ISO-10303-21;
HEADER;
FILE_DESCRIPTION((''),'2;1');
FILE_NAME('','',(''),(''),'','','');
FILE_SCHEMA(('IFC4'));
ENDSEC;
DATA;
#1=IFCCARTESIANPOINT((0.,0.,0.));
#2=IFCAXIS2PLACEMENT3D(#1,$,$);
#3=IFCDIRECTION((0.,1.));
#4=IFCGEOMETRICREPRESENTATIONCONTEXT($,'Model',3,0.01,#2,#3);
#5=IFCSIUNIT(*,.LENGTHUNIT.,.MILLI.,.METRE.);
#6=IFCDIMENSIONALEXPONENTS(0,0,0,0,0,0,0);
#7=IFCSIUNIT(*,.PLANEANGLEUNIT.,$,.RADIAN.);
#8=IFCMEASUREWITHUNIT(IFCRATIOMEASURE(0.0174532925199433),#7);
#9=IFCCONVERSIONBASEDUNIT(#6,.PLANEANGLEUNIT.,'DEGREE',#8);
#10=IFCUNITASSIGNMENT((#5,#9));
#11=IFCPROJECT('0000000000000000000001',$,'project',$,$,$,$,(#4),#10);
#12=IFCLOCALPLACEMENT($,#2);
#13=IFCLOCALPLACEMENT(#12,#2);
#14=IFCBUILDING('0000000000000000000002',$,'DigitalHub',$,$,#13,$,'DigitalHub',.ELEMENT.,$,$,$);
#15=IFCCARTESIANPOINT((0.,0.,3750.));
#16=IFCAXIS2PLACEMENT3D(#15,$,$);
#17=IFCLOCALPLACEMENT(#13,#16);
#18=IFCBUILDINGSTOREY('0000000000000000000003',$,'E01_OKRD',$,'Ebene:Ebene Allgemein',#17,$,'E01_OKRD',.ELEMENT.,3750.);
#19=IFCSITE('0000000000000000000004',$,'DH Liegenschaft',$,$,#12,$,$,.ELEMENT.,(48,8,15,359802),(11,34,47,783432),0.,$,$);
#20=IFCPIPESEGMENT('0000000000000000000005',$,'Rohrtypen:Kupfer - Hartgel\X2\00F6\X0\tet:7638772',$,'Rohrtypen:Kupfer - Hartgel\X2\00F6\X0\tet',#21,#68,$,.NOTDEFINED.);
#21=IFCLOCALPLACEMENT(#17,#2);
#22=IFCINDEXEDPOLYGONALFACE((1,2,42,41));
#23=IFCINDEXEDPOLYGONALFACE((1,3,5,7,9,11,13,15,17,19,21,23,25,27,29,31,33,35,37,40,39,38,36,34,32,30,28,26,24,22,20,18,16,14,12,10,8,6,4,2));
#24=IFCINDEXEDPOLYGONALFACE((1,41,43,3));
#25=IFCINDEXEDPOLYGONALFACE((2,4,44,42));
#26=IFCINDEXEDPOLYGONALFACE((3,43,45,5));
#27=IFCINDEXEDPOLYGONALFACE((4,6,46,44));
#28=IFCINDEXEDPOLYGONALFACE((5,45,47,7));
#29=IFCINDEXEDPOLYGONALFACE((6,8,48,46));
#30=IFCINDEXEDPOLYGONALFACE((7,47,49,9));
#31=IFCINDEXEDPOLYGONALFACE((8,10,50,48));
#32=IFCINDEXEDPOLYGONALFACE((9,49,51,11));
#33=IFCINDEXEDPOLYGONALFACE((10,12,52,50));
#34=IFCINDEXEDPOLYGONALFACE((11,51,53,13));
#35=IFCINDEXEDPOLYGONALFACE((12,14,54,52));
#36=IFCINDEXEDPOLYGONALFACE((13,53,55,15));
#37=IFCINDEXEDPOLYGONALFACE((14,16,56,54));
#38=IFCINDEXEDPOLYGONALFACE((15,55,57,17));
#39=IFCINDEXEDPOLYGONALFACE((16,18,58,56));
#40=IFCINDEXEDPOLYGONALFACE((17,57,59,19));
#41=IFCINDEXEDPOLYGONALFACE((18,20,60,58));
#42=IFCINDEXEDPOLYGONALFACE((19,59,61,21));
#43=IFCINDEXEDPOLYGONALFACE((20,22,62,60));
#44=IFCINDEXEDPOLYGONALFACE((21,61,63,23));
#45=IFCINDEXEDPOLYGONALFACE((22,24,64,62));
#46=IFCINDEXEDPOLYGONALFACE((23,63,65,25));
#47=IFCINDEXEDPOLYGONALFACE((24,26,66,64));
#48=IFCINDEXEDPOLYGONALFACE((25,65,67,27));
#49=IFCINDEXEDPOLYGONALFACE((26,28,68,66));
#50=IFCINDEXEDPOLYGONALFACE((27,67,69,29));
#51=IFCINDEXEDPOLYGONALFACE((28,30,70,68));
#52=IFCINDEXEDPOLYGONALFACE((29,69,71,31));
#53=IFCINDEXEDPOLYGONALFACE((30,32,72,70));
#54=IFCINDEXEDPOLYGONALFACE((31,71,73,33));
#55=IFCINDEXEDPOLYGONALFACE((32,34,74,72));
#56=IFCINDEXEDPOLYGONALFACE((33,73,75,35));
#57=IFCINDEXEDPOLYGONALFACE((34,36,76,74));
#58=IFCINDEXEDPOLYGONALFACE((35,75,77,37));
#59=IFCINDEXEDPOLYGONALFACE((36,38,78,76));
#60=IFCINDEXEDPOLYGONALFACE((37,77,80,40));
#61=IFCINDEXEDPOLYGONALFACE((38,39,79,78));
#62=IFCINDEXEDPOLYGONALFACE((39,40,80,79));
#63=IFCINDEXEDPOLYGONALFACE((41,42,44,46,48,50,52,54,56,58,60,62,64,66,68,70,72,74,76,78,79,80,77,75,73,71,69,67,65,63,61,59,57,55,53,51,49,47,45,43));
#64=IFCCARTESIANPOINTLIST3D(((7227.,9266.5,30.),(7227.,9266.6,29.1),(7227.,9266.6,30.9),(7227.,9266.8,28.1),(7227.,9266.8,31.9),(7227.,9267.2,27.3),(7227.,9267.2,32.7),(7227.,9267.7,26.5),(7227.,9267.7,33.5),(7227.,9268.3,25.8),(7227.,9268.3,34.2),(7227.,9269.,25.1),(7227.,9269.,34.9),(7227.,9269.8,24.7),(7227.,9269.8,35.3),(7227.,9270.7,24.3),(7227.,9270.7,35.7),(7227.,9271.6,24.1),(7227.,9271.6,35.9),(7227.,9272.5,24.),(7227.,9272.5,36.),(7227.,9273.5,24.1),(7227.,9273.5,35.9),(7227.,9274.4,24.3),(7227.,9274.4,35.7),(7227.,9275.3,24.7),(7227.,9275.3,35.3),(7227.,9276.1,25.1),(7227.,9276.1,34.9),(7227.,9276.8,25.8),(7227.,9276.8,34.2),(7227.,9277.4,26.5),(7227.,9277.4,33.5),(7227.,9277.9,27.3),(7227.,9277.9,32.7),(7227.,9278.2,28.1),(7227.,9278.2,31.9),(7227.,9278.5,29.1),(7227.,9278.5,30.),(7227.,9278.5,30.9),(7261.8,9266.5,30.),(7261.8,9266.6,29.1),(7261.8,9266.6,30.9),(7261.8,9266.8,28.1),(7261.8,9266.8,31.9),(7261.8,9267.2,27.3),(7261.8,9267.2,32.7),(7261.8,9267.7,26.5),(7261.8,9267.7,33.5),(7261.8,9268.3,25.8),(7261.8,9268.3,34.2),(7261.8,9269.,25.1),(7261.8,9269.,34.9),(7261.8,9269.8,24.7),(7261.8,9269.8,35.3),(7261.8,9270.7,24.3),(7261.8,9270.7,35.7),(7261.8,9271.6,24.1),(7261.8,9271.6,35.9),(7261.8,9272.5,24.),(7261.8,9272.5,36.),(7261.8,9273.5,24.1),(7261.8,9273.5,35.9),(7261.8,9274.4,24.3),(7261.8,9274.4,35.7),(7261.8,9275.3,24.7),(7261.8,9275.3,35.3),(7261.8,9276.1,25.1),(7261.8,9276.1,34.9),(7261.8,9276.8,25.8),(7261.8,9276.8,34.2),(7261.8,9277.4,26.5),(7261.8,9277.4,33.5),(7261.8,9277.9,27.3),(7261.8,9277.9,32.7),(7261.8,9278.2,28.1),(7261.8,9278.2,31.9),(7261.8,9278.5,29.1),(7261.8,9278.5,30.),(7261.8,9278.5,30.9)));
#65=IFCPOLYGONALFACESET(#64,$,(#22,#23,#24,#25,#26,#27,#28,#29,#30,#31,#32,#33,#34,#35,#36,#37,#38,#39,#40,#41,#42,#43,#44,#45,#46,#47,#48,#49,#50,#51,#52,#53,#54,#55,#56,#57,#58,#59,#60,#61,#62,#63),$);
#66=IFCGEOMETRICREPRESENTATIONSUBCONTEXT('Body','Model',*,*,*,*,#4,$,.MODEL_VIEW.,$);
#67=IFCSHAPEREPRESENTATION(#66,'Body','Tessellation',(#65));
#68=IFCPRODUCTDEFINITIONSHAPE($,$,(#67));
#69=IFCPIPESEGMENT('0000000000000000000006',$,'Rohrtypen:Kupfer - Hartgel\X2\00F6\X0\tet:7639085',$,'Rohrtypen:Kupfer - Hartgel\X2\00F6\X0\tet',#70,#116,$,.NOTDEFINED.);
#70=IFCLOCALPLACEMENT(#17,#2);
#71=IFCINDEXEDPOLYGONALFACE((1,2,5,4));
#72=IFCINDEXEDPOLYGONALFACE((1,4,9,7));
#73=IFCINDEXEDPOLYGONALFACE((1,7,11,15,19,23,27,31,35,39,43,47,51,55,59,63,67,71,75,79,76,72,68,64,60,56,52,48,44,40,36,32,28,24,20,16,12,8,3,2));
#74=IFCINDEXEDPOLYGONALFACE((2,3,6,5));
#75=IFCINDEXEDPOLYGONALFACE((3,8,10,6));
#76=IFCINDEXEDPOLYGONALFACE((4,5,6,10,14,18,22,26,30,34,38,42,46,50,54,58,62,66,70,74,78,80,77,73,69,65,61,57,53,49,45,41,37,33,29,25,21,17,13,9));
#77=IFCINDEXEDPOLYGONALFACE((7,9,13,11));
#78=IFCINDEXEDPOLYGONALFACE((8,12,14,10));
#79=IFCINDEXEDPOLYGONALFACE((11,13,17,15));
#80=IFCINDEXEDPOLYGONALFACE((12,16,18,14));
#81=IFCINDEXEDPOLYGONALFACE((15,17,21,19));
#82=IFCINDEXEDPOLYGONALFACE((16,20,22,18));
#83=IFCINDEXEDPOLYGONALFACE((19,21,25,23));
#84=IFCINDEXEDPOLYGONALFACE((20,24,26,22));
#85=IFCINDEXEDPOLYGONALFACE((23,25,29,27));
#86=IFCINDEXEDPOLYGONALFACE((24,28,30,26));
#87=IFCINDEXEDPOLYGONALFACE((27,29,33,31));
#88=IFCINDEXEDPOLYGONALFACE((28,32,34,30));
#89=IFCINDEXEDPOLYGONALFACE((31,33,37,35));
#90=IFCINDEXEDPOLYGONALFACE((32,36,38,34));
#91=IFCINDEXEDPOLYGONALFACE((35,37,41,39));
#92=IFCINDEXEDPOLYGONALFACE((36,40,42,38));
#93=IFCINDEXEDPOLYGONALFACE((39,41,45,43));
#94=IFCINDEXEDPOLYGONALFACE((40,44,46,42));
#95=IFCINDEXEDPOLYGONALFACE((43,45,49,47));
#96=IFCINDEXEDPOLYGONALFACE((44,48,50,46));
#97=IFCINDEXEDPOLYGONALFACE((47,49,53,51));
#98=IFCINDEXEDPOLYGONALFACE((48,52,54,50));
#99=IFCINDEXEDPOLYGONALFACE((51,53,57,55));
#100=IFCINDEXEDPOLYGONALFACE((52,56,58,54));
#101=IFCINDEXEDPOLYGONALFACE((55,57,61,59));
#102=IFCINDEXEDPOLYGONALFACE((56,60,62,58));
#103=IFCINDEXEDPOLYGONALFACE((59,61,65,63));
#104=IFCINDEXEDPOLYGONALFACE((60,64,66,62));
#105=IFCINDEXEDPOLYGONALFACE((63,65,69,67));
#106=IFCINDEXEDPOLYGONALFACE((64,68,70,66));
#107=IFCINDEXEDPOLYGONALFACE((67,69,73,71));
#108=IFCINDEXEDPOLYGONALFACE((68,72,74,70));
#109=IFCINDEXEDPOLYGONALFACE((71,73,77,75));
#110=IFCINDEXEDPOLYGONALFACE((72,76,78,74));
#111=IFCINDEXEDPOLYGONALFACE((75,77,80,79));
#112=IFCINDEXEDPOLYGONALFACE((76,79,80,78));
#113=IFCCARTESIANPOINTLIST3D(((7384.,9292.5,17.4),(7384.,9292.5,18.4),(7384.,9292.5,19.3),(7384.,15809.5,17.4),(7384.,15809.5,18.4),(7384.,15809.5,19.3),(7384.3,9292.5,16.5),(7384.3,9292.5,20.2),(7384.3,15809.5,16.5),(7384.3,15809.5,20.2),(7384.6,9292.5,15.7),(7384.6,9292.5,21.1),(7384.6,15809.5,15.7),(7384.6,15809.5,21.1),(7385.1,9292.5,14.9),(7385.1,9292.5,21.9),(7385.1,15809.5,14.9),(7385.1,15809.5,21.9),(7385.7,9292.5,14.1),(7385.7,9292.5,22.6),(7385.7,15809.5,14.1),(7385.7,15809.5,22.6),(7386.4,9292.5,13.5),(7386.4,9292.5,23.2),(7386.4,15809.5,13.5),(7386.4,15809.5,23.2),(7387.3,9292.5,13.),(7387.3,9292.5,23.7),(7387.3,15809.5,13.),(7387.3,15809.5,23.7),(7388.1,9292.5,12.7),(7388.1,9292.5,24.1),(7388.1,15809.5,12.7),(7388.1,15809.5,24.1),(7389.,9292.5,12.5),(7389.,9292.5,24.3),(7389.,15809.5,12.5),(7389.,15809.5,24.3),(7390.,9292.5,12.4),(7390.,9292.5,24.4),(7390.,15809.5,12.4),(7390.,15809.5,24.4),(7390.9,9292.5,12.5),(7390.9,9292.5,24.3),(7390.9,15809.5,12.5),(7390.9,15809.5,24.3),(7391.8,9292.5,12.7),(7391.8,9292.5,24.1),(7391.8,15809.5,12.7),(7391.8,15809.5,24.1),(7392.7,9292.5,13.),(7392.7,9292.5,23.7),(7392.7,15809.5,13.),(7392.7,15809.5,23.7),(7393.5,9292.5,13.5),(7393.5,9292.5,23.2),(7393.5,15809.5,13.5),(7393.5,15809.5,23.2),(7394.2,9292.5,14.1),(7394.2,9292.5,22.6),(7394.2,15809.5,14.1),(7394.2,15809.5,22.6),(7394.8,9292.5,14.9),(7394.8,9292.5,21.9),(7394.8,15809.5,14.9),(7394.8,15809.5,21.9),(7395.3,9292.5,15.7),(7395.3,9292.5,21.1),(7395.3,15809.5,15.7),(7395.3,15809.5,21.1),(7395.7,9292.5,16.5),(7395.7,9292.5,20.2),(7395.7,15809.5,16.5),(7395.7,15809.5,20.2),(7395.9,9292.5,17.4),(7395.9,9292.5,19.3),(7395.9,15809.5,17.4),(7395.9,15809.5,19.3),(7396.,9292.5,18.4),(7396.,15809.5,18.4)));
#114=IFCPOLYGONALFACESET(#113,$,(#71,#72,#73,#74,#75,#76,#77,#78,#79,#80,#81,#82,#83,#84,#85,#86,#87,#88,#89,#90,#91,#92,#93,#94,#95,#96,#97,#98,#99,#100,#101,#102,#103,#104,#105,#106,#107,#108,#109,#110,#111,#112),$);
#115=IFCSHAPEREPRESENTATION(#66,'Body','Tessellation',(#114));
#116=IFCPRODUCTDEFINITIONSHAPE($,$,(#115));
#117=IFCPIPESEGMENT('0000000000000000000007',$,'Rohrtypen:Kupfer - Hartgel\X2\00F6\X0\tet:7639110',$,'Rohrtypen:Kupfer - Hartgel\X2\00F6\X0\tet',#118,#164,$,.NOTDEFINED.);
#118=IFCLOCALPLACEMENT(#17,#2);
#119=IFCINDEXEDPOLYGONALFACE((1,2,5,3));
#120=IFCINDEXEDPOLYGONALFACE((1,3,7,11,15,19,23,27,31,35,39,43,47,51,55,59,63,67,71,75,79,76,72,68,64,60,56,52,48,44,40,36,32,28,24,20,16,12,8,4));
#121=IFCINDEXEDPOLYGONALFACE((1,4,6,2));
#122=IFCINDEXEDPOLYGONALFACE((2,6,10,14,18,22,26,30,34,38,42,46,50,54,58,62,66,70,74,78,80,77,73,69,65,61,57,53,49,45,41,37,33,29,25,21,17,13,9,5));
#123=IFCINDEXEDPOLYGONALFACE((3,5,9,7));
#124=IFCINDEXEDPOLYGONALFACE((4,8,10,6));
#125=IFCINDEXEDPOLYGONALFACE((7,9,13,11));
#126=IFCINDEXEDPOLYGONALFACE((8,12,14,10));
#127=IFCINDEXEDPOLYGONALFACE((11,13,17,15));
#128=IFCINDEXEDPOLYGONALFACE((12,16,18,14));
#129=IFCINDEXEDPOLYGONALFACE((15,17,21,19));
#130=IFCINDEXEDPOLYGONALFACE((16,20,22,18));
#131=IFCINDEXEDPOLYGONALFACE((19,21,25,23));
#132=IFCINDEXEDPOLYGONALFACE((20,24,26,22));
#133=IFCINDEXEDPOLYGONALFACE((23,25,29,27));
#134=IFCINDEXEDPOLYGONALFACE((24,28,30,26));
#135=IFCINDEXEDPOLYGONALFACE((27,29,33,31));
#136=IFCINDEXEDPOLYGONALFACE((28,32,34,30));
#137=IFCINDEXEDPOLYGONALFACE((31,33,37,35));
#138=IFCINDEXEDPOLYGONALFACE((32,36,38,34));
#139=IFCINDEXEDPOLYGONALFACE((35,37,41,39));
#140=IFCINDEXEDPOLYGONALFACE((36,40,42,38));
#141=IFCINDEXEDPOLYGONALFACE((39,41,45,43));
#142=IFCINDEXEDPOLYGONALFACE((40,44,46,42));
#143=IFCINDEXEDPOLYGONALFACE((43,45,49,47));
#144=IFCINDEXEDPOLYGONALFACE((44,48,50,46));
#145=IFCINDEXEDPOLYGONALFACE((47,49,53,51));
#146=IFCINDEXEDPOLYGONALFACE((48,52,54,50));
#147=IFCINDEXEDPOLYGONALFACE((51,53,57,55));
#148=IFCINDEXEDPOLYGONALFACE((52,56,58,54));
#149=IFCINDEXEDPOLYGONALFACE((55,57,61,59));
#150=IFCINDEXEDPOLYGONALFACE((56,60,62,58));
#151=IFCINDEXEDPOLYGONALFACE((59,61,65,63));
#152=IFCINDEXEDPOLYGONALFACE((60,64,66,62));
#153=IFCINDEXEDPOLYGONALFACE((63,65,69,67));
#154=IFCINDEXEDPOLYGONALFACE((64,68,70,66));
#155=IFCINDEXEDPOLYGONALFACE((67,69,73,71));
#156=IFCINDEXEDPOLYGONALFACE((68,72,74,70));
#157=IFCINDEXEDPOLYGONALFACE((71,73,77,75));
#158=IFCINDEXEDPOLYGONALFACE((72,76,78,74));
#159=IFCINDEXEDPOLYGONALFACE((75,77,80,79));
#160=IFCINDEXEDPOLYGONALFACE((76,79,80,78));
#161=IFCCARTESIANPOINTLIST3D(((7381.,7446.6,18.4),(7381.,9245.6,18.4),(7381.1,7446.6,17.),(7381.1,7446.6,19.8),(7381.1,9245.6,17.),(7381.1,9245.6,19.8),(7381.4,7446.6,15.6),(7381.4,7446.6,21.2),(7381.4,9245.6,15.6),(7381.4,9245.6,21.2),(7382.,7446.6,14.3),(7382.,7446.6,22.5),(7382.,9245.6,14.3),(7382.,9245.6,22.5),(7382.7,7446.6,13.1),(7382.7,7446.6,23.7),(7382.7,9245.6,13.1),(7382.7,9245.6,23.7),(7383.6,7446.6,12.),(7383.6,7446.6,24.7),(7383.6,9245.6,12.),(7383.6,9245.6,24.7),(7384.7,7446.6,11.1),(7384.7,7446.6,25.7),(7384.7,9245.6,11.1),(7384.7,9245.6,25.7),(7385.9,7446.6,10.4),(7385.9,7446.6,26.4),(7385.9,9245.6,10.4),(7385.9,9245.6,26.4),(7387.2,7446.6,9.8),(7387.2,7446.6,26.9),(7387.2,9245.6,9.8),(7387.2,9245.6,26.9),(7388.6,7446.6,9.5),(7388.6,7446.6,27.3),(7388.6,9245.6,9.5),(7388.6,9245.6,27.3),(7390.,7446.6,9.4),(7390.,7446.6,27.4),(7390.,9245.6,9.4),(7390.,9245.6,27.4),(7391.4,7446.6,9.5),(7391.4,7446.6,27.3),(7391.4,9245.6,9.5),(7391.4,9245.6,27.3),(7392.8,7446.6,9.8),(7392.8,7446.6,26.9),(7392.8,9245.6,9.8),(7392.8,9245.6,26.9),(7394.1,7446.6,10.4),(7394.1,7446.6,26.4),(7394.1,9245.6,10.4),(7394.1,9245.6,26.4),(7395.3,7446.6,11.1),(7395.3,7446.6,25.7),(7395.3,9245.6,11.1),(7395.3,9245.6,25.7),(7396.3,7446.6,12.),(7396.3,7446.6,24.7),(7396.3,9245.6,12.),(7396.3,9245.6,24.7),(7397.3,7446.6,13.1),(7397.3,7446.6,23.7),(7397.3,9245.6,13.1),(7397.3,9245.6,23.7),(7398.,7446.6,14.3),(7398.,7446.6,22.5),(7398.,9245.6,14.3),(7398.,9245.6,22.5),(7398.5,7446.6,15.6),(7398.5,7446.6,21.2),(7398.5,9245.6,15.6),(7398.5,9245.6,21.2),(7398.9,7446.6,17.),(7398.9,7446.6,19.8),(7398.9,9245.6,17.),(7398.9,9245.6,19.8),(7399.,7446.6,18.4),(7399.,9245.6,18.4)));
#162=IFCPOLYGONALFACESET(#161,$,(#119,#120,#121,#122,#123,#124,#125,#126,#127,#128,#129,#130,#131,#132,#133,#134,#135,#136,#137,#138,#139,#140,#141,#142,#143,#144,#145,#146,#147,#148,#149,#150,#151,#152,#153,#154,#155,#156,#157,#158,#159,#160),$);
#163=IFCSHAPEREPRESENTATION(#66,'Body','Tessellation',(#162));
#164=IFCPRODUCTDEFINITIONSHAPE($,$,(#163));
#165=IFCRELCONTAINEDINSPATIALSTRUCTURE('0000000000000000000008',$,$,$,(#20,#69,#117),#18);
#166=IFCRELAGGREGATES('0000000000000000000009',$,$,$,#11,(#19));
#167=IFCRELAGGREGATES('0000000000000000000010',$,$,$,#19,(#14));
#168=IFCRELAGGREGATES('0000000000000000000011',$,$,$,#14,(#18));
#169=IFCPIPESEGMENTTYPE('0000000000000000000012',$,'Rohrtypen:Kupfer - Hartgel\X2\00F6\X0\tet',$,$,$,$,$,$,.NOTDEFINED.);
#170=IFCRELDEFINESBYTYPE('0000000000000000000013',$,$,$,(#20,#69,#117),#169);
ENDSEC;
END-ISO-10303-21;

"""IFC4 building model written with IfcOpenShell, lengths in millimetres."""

from ifc_helpers import new_model, entity, si_unit, converted_unit, direction, frame, origin, place, context, subcontext, project, spatial, indexed_curve, outline, extrude, type_object, element, save


model = new_model("IFC4")

# Units and contexts
model_context = context("Model", 3, precision=0.01, world=origin(), true_north=direction((0.0, 1.0)))
body_context = subcontext(model_context, "Body", "Model", "MODEL_VIEW")
ifc_project = project(units=[si_unit("LENGTHUNIT", "METRE", prefix="MILLI"), converted_unit("PLANEANGLEUNIT", "DEGREE", entity("IfcRatioMeasure", 0.0174532925199433), si_unit("PLANEANGLEUNIT", "RADIAN"), dimensions=[0, 0, 0, 0, 0, 0, 0])], contexts=[model_context])

# Site, building, storey
site_placement = place(None, origin())
site = spatial("IfcSite", under=ifc_project, at=site_placement, Name="DH Liegenschaft", CompositionType="ELEMENT", RefLatitude=(48, 8, 15, 359802), RefLongitude=(11, 34, 47, 783432), RefElevation=0.0)
building_placement = place(site_placement, origin())
building = spatial("IfcBuilding", under=site, at=building_placement, Name="DigitalHub", LongName="DigitalHub", CompositionType="ELEMENT")
storey_placement = place(building_placement, frame((0.0, 0.0, 3750.0)))
storey = spatial("IfcBuildingStorey", under=building, at=storey_placement, Name="E01_OKRD", ObjectType="Ebene:Ebene Allgemein", LongName="E01_OKRD", CompositionType="ELEMENT", Elevation=3750.0)

# Pipe segments
pipe_segment_type = type_object("IfcPipeSegmentType", Name="Rohrtypen:Kupfer - Hartgelötet", PredefinedType="NOTDEFINED")
pipe_segment_1_placement = place(storey_placement, frame((7227.0, 9264.9, 22.4)))
element("IfcPipeSegment", 1, at=pipe_segment_1_placement, inside=storey, type_object=pipe_segment_type, Name="Rohrtypen:Kupfer - Hartgelötet:7638772", ObjectType="Rohrtypen:Kupfer - Hartgelötet", PredefinedType="NOTDEFINED", context=body_context, shape_type="SweptSolid", body=[
    extrude(outline(indexed_curve([(6.0, 0.0), (5.9, 0.9), (5.7, 1.9), (5.3, 2.7), (4.9, 3.5), (4.2, 4.2), (3.5, 4.9), (2.7, 5.3), (1.9, 5.7), (0.9, 5.9), (0.0, 6.0), (-0.9, 5.9), (-1.9, 5.7), (-2.7, 5.3), (-3.5, 4.9), (-4.2, 4.2), (-4.9, 3.5), (-5.3, 2.7), (-5.7, 1.9), (-5.9, 0.9), (-6.0, 0.0), (-5.9, -0.9), (-5.7, -1.9), (-5.3, -2.7), (-4.9, -3.5), (-4.2, -4.2), (-3.5, -4.9), (-2.7, -5.3), (-1.9, -5.7), (-0.9, -5.9), (0.0, -6.0), (0.9, -5.9), (1.9, -5.7), (2.7, -5.3), (3.5, -4.9), (4.2, -4.2), (4.9, -3.5), (5.3, -2.7), (5.7, -1.9), (5.9, -0.9), (6.0, 0.0)], self_intersect=False)), frame((0.0, 7.6, 7.6), z_axis=(1.0, 0.0, 0.0), x_axis=(0.0, 1.0, 0.0)), (0.0, 0.0, 1.0), 34.9),
])
pipe_segment_2_placement = place(storey_placement, frame((7382.4, 9292.5, 10.8)))
element("IfcPipeSegment", 2, at=pipe_segment_2_placement, inside=storey, type_object=pipe_segment_type, Name="Rohrtypen:Kupfer - Hartgelötet:7639085", ObjectType="Rohrtypen:Kupfer - Hartgelötet", PredefinedType="NOTDEFINED", context=body_context, shape_type="SweptSolid", body=[
    extrude(outline(indexed_curve([(6.0, 0.0), (5.9, 0.9), (5.7, 1.9), (5.3, 2.7), (4.9, 3.5), (4.2, 4.2), (3.5, 4.9), (2.7, 5.3), (1.9, 5.7), (0.9, 5.9), (0.0, 6.0), (-0.9, 5.9), (-1.9, 5.7), (-2.7, 5.3), (-3.5, 4.9), (-4.2, 4.2), (-4.9, 3.5), (-5.3, 2.7), (-5.7, 1.9), (-5.9, 0.9), (-6.0, 0.0), (-5.9, -0.9), (-5.7, -1.9), (-5.3, -2.7), (-4.9, -3.5), (-4.2, -4.2), (-3.5, -4.9), (-2.7, -5.3), (-1.9, -5.7), (-0.9, -5.9), (0.0, -6.0), (0.9, -5.9), (1.9, -5.7), (2.7, -5.3), (3.5, -4.9), (4.2, -4.2), (4.9, -3.5), (5.3, -2.7), (5.7, -1.9), (5.9, -0.9), (6.0, 0.0)], self_intersect=False)), frame((7.6, 0.0, 7.6), z_axis=(0.0, 1.0, 0.0), x_axis=(-1.0, 0.0, 0.0)), (0.0, 0.0, 1.0), 6517.0),
])
pipe_segment_3_placement = place(storey_placement, frame((7379.4, 7446.6, 7.8)))
element("IfcPipeSegment", 3, at=pipe_segment_3_placement, inside=storey, type_object=pipe_segment_type, Name="Rohrtypen:Kupfer - Hartgelötet:7639110", ObjectType="Rohrtypen:Kupfer - Hartgelötet", PredefinedType="NOTDEFINED", context=body_context, shape_type="SweptSolid", body=[
    extrude(outline(indexed_curve([(9.0, 0.0), (8.9, 1.4), (8.6, 2.8), (8.0, 4.1), (7.3, 5.3), (6.4, 6.4), (5.3, 7.3), (4.1, 8.0), (2.8, 8.6), (1.4, 8.9), (0.0, 9.0), (-1.4, 8.9), (-2.8, 8.6), (-4.1, 8.0), (-5.3, 7.3), (-6.4, 6.4), (-7.3, 5.3), (-8.0, 4.1), (-8.6, 2.8), (-8.9, 1.4), (-9.0, 0.0), (-8.9, -1.4), (-8.6, -2.8), (-8.0, -4.1), (-7.3, -5.3), (-6.4, -6.4), (-5.3, -7.3), (-4.1, -8.0), (-2.8, -8.6), (-1.4, -8.9), (0.0, -9.0), (1.4, -8.9), (2.8, -8.6), (4.1, -8.0), (5.3, -7.3), (6.4, -6.4), (7.3, -5.3), (8.0, -4.1), (8.6, -2.8), (8.9, -1.4), (9.0, 0.0)], self_intersect=False)), frame((10.6, 0.0, 10.6), z_axis=(0.0, 1.0, 0.0), x_axis=(-1.0, 0.0, 0.0)), (0.0, 0.0, 1.0), 1799.1),
])

save(model, "model.ifc")
